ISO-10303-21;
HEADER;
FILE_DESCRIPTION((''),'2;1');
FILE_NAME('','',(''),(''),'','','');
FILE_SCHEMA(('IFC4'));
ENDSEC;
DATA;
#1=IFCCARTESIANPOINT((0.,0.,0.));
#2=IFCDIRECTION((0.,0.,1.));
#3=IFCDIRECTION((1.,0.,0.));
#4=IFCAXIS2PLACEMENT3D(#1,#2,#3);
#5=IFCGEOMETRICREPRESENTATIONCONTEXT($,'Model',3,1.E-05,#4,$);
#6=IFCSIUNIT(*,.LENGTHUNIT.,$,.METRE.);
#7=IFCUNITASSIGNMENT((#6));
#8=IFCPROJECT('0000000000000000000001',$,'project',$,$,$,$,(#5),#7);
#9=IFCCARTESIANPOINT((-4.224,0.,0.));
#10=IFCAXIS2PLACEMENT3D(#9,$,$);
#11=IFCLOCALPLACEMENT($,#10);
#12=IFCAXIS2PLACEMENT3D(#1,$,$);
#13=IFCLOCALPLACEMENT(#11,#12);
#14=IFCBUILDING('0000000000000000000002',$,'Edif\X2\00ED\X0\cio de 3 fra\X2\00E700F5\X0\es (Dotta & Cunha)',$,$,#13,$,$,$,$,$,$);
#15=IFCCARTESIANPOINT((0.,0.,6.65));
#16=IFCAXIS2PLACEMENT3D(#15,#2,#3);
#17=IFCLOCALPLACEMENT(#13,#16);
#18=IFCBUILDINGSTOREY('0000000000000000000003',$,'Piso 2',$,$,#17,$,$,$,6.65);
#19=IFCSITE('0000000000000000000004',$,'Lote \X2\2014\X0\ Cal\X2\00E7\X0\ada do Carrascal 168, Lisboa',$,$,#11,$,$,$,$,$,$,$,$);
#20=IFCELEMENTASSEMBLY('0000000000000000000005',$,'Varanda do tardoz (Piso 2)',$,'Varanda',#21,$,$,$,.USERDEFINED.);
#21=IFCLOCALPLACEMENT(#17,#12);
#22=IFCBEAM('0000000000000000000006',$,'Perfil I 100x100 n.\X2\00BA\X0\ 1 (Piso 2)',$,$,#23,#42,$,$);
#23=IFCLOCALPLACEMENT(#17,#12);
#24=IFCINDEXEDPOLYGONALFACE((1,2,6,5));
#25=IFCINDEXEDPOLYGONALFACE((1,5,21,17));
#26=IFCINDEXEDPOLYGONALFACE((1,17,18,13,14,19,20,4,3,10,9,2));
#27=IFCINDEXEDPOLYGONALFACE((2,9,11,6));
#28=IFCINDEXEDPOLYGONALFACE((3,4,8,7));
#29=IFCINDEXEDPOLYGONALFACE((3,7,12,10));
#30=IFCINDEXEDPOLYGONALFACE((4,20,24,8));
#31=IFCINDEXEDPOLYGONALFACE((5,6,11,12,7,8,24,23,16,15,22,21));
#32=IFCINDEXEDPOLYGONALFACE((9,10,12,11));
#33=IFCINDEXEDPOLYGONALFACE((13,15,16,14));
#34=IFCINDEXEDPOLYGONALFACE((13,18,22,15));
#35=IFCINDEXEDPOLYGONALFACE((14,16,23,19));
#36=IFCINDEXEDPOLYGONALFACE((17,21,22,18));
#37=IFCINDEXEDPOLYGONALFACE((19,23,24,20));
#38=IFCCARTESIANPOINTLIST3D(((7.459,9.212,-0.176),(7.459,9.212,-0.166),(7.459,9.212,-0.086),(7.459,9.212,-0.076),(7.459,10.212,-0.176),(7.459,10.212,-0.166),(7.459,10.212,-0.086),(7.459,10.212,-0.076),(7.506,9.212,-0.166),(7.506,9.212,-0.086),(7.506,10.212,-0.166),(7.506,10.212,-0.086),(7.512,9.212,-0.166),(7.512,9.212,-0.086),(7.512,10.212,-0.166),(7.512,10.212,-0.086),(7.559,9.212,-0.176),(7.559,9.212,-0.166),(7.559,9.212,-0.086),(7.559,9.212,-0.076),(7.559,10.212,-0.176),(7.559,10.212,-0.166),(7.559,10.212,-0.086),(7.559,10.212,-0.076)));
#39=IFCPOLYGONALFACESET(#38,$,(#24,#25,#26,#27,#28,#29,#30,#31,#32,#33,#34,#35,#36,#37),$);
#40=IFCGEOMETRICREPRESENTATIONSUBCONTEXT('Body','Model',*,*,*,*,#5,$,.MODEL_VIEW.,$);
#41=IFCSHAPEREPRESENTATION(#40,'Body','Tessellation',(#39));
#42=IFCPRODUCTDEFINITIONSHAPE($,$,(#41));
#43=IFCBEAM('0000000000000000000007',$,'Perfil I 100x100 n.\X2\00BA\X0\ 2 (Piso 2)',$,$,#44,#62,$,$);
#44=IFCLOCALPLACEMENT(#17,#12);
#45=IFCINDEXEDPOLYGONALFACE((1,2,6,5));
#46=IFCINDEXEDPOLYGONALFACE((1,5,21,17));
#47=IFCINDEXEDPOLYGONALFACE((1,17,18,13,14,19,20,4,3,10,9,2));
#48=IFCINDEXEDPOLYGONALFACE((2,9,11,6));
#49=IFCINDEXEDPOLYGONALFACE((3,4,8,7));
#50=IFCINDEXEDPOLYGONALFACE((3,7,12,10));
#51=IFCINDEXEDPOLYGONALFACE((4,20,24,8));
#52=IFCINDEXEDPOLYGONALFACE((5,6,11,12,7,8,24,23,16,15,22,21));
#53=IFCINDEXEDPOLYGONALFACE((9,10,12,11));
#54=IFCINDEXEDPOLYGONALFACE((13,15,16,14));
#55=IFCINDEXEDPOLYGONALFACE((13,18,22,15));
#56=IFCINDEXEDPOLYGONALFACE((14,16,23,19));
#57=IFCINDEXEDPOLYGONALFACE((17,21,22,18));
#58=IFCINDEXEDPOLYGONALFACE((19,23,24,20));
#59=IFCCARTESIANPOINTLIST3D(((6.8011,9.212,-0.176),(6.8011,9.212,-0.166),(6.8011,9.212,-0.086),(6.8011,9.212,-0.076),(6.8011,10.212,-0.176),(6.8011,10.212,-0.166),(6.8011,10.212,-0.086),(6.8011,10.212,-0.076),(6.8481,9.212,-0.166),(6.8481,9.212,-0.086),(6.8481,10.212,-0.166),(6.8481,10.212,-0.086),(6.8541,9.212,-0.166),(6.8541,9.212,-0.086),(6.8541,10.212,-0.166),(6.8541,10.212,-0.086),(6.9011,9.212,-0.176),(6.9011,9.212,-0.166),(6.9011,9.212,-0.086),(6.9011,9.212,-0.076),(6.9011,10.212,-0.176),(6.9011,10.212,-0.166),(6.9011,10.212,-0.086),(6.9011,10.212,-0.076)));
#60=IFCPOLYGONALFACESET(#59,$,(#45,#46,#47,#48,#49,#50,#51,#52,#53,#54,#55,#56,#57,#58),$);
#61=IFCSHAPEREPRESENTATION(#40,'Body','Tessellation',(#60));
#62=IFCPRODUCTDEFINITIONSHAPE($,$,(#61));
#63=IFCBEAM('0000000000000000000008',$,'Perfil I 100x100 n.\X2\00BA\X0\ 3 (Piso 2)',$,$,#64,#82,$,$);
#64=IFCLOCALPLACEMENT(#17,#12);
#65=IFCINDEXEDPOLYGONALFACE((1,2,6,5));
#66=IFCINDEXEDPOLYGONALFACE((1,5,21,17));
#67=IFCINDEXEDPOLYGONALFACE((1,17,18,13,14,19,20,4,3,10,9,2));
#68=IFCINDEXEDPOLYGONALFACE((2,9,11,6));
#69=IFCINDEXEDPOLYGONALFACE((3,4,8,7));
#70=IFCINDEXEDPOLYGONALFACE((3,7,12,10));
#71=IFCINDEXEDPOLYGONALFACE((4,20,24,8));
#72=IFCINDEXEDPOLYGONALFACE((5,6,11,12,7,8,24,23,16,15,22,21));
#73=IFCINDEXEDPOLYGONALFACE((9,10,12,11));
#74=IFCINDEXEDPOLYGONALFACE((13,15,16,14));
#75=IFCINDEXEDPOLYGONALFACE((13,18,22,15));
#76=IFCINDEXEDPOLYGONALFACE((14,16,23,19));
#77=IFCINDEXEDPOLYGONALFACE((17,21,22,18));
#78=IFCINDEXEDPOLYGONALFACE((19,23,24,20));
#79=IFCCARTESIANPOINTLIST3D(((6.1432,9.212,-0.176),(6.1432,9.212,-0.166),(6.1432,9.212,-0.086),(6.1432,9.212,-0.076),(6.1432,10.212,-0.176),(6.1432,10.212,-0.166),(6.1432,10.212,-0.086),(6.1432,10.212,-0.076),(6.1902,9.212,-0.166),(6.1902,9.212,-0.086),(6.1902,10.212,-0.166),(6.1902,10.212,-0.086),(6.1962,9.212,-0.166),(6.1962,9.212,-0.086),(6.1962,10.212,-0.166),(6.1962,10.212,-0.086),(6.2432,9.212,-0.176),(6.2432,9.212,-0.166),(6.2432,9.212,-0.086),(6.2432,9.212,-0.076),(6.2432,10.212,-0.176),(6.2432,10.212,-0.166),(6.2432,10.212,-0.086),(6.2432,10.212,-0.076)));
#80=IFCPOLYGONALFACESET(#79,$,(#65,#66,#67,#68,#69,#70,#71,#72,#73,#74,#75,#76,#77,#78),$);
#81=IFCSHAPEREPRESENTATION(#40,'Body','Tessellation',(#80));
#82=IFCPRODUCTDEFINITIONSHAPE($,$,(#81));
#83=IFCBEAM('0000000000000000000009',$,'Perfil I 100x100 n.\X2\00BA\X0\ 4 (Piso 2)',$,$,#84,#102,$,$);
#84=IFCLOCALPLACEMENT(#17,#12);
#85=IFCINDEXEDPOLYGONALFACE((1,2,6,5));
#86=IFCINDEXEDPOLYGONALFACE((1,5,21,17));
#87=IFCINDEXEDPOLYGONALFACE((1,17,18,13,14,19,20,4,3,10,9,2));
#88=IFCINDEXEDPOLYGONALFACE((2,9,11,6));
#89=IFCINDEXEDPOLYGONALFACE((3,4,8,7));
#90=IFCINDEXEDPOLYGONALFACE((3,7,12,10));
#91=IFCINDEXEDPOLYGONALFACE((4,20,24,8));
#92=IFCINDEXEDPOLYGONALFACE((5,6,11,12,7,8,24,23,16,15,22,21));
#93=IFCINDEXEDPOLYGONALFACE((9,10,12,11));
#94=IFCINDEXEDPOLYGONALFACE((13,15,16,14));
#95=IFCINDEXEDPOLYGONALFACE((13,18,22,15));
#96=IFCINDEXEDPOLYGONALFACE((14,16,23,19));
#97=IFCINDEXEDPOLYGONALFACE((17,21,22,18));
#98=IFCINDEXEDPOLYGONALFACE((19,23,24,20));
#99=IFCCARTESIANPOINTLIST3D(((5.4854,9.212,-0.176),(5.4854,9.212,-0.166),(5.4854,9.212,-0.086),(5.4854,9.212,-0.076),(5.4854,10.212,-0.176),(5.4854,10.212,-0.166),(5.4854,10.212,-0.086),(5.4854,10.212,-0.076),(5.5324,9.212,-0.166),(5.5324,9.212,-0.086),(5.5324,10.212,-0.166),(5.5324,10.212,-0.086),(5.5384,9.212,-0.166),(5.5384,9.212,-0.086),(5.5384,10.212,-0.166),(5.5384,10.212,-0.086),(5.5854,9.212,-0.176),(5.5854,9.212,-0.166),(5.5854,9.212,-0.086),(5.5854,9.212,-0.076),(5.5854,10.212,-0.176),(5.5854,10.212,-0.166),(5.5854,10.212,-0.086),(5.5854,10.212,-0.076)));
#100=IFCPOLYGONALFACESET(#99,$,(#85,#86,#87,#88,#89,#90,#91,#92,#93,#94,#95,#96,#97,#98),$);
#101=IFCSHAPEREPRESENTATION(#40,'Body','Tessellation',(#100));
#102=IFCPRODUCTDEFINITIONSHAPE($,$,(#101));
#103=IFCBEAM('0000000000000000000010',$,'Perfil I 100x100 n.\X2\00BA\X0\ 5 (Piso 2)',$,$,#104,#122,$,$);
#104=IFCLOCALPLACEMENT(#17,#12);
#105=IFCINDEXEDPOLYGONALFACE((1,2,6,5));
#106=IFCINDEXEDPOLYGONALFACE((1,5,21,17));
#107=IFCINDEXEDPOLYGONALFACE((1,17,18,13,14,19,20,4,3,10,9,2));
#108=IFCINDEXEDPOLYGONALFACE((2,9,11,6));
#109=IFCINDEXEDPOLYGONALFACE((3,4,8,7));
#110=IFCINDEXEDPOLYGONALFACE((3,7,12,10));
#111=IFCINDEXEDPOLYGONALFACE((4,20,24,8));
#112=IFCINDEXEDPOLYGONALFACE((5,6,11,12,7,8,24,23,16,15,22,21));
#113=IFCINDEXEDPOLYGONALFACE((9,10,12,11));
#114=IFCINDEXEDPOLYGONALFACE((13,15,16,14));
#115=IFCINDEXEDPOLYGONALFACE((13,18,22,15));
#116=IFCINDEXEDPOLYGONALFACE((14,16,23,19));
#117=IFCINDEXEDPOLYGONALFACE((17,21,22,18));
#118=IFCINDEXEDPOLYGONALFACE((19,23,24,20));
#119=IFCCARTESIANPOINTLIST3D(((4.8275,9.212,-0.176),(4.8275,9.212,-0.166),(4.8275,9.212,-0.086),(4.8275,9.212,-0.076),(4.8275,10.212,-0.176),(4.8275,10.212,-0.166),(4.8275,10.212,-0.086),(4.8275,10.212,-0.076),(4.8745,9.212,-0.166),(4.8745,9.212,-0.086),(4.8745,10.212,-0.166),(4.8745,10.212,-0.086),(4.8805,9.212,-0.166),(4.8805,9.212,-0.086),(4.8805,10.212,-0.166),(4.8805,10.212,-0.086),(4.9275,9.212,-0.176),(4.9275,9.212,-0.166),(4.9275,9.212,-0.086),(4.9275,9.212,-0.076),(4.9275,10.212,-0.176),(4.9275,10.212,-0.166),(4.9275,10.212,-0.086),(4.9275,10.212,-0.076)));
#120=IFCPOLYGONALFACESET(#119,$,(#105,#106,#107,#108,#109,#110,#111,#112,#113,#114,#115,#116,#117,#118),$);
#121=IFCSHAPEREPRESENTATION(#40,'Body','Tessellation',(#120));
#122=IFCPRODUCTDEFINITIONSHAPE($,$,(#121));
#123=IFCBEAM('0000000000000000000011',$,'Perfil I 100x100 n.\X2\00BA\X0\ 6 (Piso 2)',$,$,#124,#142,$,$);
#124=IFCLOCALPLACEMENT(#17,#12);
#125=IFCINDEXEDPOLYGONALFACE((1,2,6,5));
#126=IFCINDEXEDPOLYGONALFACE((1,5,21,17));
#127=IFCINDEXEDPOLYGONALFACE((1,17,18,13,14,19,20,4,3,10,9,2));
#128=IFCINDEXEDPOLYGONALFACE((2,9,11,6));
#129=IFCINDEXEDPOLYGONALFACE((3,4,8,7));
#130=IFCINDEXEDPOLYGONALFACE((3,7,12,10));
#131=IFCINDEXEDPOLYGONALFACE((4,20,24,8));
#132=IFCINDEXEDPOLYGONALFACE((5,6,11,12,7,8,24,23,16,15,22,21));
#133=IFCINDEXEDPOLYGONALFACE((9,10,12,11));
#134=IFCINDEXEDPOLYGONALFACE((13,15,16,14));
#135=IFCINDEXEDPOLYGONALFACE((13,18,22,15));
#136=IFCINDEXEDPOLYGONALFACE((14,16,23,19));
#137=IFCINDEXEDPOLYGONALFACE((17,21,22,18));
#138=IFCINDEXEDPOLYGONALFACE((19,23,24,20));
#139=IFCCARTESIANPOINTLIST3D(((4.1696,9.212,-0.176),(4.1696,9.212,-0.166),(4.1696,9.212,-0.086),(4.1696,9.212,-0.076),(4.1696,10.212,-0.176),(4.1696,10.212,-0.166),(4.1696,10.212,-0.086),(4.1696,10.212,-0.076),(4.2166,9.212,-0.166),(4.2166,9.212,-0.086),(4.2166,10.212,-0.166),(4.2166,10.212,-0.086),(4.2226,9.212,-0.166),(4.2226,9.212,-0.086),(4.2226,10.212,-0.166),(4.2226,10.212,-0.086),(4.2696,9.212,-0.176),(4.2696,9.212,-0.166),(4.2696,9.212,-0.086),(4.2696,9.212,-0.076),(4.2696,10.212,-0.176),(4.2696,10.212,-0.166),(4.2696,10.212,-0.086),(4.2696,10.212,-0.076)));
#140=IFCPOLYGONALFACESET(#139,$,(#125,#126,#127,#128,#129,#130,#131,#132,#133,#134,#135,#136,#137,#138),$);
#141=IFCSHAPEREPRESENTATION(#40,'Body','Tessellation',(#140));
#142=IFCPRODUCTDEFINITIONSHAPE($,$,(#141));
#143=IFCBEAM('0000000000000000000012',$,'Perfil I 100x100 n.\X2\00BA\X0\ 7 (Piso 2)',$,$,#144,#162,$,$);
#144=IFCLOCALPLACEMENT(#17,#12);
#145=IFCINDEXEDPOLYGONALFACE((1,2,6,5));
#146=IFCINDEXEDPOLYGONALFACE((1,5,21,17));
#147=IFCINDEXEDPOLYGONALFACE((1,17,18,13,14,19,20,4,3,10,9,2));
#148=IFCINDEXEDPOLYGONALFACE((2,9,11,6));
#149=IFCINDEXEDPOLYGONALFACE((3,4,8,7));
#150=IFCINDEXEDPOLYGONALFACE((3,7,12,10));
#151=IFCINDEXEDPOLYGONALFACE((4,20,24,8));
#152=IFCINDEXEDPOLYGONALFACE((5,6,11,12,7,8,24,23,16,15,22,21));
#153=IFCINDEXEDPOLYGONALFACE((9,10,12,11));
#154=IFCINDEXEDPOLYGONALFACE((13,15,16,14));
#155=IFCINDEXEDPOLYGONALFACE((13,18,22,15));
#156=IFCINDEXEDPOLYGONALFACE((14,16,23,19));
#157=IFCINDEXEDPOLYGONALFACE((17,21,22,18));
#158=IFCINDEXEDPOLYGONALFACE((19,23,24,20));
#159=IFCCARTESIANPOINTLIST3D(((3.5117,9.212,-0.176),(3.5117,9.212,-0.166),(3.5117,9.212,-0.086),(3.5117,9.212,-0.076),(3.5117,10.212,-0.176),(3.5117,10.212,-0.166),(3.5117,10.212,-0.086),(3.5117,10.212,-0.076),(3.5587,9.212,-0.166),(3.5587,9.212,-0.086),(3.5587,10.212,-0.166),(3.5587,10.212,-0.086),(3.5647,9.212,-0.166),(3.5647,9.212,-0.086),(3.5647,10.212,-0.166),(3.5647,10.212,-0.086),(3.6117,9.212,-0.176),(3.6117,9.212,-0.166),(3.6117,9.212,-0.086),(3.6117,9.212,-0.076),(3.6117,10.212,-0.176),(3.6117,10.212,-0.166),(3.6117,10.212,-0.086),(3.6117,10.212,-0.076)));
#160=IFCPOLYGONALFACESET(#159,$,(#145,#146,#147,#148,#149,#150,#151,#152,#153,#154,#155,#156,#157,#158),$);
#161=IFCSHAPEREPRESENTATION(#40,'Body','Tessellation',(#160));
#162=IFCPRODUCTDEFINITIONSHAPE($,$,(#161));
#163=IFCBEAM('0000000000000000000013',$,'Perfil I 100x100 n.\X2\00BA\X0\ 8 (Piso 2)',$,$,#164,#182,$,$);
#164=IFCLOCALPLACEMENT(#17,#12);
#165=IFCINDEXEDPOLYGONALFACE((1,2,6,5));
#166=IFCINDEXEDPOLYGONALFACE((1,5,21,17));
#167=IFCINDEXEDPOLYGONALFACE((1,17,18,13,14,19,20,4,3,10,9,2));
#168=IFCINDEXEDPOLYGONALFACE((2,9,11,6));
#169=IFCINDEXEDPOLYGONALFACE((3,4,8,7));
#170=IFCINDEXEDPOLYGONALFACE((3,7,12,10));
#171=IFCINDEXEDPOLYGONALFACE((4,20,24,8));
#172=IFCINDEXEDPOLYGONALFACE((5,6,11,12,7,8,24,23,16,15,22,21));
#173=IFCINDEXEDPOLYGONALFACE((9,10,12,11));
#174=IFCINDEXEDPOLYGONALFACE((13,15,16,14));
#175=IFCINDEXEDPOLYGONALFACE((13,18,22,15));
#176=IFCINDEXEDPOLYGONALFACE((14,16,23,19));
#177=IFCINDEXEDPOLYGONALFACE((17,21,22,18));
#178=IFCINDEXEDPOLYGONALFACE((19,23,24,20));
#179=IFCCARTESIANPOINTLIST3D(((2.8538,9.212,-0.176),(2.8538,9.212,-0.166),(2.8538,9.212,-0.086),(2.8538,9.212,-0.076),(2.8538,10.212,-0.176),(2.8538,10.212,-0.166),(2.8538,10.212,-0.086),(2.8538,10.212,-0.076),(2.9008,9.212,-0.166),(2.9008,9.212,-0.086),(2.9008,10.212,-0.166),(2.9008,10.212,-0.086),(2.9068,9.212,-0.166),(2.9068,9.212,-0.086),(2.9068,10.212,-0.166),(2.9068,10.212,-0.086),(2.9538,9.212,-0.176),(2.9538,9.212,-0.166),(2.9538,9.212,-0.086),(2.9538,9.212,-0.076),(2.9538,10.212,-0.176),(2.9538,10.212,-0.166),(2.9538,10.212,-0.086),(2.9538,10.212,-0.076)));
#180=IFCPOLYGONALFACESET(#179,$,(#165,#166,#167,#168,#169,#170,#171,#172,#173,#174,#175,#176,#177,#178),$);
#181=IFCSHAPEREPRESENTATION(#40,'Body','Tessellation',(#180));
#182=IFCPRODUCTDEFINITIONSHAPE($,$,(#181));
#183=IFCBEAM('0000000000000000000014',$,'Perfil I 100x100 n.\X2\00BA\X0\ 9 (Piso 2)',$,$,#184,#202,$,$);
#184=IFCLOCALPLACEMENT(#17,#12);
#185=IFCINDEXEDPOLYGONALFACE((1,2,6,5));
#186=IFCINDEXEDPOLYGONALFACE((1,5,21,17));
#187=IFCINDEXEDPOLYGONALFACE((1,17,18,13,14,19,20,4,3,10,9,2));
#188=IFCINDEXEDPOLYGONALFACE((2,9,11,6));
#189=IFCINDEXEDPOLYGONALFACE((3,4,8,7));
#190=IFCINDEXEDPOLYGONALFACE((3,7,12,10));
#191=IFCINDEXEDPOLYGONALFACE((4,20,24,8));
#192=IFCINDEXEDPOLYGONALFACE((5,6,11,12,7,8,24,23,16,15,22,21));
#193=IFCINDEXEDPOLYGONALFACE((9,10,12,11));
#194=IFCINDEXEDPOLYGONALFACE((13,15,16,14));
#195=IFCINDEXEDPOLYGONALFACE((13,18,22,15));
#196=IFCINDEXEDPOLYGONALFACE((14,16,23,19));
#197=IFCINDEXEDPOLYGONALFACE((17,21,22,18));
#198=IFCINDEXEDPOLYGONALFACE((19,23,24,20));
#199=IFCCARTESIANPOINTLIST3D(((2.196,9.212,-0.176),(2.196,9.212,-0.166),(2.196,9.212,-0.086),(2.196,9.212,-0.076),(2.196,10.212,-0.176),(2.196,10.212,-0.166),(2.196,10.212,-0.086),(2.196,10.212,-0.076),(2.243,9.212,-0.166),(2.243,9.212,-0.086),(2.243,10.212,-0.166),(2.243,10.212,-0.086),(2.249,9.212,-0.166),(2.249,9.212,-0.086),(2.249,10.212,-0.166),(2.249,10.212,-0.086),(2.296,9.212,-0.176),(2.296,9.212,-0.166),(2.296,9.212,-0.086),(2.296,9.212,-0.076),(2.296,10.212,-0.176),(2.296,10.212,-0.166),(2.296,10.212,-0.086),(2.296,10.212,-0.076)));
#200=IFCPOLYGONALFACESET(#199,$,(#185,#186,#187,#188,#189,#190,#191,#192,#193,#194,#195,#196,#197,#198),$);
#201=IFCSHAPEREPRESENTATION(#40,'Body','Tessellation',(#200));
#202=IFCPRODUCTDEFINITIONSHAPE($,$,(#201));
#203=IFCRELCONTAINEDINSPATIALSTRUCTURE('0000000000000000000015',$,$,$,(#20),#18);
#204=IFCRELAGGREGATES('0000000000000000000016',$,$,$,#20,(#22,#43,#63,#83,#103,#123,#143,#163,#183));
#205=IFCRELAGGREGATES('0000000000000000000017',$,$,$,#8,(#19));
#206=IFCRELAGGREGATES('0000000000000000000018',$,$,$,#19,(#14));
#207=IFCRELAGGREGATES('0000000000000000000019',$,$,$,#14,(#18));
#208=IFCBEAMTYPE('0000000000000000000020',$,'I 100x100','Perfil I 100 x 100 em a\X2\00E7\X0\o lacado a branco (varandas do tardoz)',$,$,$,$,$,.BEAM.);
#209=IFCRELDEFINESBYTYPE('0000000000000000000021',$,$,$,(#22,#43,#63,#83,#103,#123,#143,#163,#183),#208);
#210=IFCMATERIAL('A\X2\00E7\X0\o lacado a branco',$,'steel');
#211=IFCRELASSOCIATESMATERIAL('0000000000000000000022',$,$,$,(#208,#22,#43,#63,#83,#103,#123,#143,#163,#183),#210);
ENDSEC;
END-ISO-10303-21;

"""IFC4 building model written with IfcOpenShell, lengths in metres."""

from ifc_helpers import new_model, si_unit, frame, origin, origin_with_axes, place, context, subcontext, project, spatial, i_section, extrude, material, type_object, element, aggregate, save


model = new_model("IFC4")

# Units and contexts
model_context = context("Model", 3, precision=1e-05, world=origin_with_axes())
body_context = subcontext(model_context, "Body", "Model", "MODEL_VIEW")
ifc_project = project(units=[si_unit("LENGTHUNIT", "METRE")], contexts=[model_context])

# Site, building, storey
site_placement = place(None, frame((-4.224, 0.0, 0.0)))
site = spatial("IfcSite", under=ifc_project, at=site_placement, Name="Lote — Calçada do Carrascal 168, Lisboa")
building_placement = place(site_placement, origin())
building = spatial("IfcBuilding", under=site, at=building_placement, Name="Edifício de 3 frações (Dotta & Cunha)")
storey_placement = place(building_placement, frame((0.0, 0.0, 6.65), z_axis=(0.0, 0.0, 1.0), x_axis=(1.0, 0.0, 0.0)))
storey = spatial("IfcBuildingStorey", under=building, at=storey_placement, Name="Piso 2", Elevation=6.65)

# Element assembly, beams
assembly_1 = element("IfcElementAssembly", 1, inside=storey, Name="Varanda do tardoz (Piso 2)", ObjectType="Varanda", PredefinedType="USERDEFINED")
ifc_material_1 = material(Name="Aço lacado a branco", Category="steel")
beam_type = type_object("IfcBeamType", Name="I 100x100", Description="Perfil I 100 x 100 em aço lacado a branco (varandas do tardoz)", PredefinedType="BEAM", material=ifc_material_1)
beam_1_placement = place(building_placement, origin_with_axes())
beam_1 = element("IfcBeam", 2, at=beam_1_placement, type_object=beam_type, material=ifc_material_1, Name="Perfil I 100x100 n.º 1 (Piso 2)", context=body_context, shape_type="SweptSolid", body=[
    extrude(i_section(OverallWidth=0.1, OverallDepth=0.1, WebThickness=0.006, FlangeThickness=0.01), frame((7.509, 9.212, 6.524), z_axis=(0.0, 1.0, 0.0), x_axis=(-1.0, 0.0, 0.0)), (0.0, 0.0, 1.0), 1.0),
])
beam_2_placement = place(building_placement, origin_with_axes())
beam_2 = element("IfcBeam", 3, at=beam_2_placement, type_object=beam_type, material=ifc_material_1, Name="Perfil I 100x100 n.º 2 (Piso 2)", context=body_context, shape_type="SweptSolid", body=[
    extrude(i_section(OverallWidth=0.1, OverallDepth=0.1, WebThickness=0.006, FlangeThickness=0.01), frame((6.8511, 9.212, 6.524), z_axis=(0.0, 1.0, 0.0), x_axis=(-1.0, 0.0, 0.0)), (0.0, 0.0, 1.0), 1.0),
])
beam_3_placement = place(building_placement, origin_with_axes())
beam_3 = element("IfcBeam", 4, at=beam_3_placement, type_object=beam_type, material=ifc_material_1, Name="Perfil I 100x100 n.º 3 (Piso 2)", context=body_context, shape_type="SweptSolid", body=[
    extrude(i_section(OverallWidth=0.1, OverallDepth=0.1, WebThickness=0.006, FlangeThickness=0.01), frame((6.1932, 9.212, 6.524), z_axis=(0.0, 1.0, 0.0), x_axis=(-1.0, 0.0, 0.0)), (0.0, 0.0, 1.0), 1.0),
])
beam_4_placement = place(building_placement, origin_with_axes())
beam_4 = element("IfcBeam", 5, at=beam_4_placement, type_object=beam_type, material=ifc_material_1, Name="Perfil I 100x100 n.º 4 (Piso 2)", context=body_context, shape_type="SweptSolid", body=[
    extrude(i_section(OverallWidth=0.1, OverallDepth=0.1, WebThickness=0.006, FlangeThickness=0.01), frame((5.5354, 9.212, 6.524), z_axis=(0.0, 1.0, 0.0), x_axis=(-1.0, 0.0, 0.0)), (0.0, 0.0, 1.0), 1.0),
])
beam_5_placement = place(building_placement, origin_with_axes())
beam_5 = element("IfcBeam", 6, at=beam_5_placement, type_object=beam_type, material=ifc_material_1, Name="Perfil I 100x100 n.º 5 (Piso 2)", context=body_context, shape_type="SweptSolid", body=[
    extrude(i_section(OverallWidth=0.1, OverallDepth=0.1, WebThickness=0.006, FlangeThickness=0.01), frame((4.8775, 9.212, 6.524), z_axis=(0.0, 1.0, 0.0), x_axis=(-1.0, 0.0, 0.0)), (0.0, 0.0, 1.0), 1.0),
])
beam_6_placement = place(building_placement, origin_with_axes())
beam_6 = element("IfcBeam", 7, at=beam_6_placement, type_object=beam_type, material=ifc_material_1, Name="Perfil I 100x100 n.º 6 (Piso 2)", context=body_context, shape_type="SweptSolid", body=[
    extrude(i_section(OverallWidth=0.1, OverallDepth=0.1, WebThickness=0.006, FlangeThickness=0.01), frame((4.2196, 9.212, 6.524), z_axis=(0.0, 1.0, 0.0), x_axis=(-1.0, 0.0, 0.0)), (0.0, 0.0, 1.0), 1.0),
])
beam_7_placement = place(building_placement, origin_with_axes())
beam_7 = element("IfcBeam", 8, at=beam_7_placement, type_object=beam_type, material=ifc_material_1, Name="Perfil I 100x100 n.º 7 (Piso 2)", context=body_context, shape_type="SweptSolid", body=[
    extrude(i_section(OverallWidth=0.1, OverallDepth=0.1, WebThickness=0.006, FlangeThickness=0.01), frame((3.5617, 9.212, 6.524), z_axis=(0.0, 1.0, 0.0), x_axis=(-1.0, 0.0, 0.0)), (0.0, 0.0, 1.0), 1.0),
])
beam_8_placement = place(building_placement, origin_with_axes())
beam_8 = element("IfcBeam", 9, at=beam_8_placement, type_object=beam_type, material=ifc_material_1, Name="Perfil I 100x100 n.º 8 (Piso 2)", context=body_context, shape_type="SweptSolid", body=[
    extrude(i_section(OverallWidth=0.1, OverallDepth=0.1, WebThickness=0.006, FlangeThickness=0.01), frame((2.9038, 9.212, 6.524), z_axis=(0.0, 1.0, 0.0), x_axis=(-1.0, 0.0, 0.0)), (0.0, 0.0, 1.0), 1.0),
])
beam_9_placement = place(building_placement, origin_with_axes())
beam_9 = element("IfcBeam", 10, at=beam_9_placement, type_object=beam_type, material=ifc_material_1, Name="Perfil I 100x100 n.º 9 (Piso 2)", context=body_context, shape_type="SweptSolid", body=[
    extrude(i_section(OverallWidth=0.1, OverallDepth=0.1, WebThickness=0.006, FlangeThickness=0.01), frame((2.246, 9.212, 6.524), z_axis=(0.0, 1.0, 0.0), x_axis=(-1.0, 0.0, 0.0)), (0.0, 0.0, 1.0), 1.0),
])

aggregate(assembly_1, [beam_1, beam_2, beam_3, beam_4, beam_5, beam_6, beam_7, beam_8, beam_9])

save(model, "model.ifc")
